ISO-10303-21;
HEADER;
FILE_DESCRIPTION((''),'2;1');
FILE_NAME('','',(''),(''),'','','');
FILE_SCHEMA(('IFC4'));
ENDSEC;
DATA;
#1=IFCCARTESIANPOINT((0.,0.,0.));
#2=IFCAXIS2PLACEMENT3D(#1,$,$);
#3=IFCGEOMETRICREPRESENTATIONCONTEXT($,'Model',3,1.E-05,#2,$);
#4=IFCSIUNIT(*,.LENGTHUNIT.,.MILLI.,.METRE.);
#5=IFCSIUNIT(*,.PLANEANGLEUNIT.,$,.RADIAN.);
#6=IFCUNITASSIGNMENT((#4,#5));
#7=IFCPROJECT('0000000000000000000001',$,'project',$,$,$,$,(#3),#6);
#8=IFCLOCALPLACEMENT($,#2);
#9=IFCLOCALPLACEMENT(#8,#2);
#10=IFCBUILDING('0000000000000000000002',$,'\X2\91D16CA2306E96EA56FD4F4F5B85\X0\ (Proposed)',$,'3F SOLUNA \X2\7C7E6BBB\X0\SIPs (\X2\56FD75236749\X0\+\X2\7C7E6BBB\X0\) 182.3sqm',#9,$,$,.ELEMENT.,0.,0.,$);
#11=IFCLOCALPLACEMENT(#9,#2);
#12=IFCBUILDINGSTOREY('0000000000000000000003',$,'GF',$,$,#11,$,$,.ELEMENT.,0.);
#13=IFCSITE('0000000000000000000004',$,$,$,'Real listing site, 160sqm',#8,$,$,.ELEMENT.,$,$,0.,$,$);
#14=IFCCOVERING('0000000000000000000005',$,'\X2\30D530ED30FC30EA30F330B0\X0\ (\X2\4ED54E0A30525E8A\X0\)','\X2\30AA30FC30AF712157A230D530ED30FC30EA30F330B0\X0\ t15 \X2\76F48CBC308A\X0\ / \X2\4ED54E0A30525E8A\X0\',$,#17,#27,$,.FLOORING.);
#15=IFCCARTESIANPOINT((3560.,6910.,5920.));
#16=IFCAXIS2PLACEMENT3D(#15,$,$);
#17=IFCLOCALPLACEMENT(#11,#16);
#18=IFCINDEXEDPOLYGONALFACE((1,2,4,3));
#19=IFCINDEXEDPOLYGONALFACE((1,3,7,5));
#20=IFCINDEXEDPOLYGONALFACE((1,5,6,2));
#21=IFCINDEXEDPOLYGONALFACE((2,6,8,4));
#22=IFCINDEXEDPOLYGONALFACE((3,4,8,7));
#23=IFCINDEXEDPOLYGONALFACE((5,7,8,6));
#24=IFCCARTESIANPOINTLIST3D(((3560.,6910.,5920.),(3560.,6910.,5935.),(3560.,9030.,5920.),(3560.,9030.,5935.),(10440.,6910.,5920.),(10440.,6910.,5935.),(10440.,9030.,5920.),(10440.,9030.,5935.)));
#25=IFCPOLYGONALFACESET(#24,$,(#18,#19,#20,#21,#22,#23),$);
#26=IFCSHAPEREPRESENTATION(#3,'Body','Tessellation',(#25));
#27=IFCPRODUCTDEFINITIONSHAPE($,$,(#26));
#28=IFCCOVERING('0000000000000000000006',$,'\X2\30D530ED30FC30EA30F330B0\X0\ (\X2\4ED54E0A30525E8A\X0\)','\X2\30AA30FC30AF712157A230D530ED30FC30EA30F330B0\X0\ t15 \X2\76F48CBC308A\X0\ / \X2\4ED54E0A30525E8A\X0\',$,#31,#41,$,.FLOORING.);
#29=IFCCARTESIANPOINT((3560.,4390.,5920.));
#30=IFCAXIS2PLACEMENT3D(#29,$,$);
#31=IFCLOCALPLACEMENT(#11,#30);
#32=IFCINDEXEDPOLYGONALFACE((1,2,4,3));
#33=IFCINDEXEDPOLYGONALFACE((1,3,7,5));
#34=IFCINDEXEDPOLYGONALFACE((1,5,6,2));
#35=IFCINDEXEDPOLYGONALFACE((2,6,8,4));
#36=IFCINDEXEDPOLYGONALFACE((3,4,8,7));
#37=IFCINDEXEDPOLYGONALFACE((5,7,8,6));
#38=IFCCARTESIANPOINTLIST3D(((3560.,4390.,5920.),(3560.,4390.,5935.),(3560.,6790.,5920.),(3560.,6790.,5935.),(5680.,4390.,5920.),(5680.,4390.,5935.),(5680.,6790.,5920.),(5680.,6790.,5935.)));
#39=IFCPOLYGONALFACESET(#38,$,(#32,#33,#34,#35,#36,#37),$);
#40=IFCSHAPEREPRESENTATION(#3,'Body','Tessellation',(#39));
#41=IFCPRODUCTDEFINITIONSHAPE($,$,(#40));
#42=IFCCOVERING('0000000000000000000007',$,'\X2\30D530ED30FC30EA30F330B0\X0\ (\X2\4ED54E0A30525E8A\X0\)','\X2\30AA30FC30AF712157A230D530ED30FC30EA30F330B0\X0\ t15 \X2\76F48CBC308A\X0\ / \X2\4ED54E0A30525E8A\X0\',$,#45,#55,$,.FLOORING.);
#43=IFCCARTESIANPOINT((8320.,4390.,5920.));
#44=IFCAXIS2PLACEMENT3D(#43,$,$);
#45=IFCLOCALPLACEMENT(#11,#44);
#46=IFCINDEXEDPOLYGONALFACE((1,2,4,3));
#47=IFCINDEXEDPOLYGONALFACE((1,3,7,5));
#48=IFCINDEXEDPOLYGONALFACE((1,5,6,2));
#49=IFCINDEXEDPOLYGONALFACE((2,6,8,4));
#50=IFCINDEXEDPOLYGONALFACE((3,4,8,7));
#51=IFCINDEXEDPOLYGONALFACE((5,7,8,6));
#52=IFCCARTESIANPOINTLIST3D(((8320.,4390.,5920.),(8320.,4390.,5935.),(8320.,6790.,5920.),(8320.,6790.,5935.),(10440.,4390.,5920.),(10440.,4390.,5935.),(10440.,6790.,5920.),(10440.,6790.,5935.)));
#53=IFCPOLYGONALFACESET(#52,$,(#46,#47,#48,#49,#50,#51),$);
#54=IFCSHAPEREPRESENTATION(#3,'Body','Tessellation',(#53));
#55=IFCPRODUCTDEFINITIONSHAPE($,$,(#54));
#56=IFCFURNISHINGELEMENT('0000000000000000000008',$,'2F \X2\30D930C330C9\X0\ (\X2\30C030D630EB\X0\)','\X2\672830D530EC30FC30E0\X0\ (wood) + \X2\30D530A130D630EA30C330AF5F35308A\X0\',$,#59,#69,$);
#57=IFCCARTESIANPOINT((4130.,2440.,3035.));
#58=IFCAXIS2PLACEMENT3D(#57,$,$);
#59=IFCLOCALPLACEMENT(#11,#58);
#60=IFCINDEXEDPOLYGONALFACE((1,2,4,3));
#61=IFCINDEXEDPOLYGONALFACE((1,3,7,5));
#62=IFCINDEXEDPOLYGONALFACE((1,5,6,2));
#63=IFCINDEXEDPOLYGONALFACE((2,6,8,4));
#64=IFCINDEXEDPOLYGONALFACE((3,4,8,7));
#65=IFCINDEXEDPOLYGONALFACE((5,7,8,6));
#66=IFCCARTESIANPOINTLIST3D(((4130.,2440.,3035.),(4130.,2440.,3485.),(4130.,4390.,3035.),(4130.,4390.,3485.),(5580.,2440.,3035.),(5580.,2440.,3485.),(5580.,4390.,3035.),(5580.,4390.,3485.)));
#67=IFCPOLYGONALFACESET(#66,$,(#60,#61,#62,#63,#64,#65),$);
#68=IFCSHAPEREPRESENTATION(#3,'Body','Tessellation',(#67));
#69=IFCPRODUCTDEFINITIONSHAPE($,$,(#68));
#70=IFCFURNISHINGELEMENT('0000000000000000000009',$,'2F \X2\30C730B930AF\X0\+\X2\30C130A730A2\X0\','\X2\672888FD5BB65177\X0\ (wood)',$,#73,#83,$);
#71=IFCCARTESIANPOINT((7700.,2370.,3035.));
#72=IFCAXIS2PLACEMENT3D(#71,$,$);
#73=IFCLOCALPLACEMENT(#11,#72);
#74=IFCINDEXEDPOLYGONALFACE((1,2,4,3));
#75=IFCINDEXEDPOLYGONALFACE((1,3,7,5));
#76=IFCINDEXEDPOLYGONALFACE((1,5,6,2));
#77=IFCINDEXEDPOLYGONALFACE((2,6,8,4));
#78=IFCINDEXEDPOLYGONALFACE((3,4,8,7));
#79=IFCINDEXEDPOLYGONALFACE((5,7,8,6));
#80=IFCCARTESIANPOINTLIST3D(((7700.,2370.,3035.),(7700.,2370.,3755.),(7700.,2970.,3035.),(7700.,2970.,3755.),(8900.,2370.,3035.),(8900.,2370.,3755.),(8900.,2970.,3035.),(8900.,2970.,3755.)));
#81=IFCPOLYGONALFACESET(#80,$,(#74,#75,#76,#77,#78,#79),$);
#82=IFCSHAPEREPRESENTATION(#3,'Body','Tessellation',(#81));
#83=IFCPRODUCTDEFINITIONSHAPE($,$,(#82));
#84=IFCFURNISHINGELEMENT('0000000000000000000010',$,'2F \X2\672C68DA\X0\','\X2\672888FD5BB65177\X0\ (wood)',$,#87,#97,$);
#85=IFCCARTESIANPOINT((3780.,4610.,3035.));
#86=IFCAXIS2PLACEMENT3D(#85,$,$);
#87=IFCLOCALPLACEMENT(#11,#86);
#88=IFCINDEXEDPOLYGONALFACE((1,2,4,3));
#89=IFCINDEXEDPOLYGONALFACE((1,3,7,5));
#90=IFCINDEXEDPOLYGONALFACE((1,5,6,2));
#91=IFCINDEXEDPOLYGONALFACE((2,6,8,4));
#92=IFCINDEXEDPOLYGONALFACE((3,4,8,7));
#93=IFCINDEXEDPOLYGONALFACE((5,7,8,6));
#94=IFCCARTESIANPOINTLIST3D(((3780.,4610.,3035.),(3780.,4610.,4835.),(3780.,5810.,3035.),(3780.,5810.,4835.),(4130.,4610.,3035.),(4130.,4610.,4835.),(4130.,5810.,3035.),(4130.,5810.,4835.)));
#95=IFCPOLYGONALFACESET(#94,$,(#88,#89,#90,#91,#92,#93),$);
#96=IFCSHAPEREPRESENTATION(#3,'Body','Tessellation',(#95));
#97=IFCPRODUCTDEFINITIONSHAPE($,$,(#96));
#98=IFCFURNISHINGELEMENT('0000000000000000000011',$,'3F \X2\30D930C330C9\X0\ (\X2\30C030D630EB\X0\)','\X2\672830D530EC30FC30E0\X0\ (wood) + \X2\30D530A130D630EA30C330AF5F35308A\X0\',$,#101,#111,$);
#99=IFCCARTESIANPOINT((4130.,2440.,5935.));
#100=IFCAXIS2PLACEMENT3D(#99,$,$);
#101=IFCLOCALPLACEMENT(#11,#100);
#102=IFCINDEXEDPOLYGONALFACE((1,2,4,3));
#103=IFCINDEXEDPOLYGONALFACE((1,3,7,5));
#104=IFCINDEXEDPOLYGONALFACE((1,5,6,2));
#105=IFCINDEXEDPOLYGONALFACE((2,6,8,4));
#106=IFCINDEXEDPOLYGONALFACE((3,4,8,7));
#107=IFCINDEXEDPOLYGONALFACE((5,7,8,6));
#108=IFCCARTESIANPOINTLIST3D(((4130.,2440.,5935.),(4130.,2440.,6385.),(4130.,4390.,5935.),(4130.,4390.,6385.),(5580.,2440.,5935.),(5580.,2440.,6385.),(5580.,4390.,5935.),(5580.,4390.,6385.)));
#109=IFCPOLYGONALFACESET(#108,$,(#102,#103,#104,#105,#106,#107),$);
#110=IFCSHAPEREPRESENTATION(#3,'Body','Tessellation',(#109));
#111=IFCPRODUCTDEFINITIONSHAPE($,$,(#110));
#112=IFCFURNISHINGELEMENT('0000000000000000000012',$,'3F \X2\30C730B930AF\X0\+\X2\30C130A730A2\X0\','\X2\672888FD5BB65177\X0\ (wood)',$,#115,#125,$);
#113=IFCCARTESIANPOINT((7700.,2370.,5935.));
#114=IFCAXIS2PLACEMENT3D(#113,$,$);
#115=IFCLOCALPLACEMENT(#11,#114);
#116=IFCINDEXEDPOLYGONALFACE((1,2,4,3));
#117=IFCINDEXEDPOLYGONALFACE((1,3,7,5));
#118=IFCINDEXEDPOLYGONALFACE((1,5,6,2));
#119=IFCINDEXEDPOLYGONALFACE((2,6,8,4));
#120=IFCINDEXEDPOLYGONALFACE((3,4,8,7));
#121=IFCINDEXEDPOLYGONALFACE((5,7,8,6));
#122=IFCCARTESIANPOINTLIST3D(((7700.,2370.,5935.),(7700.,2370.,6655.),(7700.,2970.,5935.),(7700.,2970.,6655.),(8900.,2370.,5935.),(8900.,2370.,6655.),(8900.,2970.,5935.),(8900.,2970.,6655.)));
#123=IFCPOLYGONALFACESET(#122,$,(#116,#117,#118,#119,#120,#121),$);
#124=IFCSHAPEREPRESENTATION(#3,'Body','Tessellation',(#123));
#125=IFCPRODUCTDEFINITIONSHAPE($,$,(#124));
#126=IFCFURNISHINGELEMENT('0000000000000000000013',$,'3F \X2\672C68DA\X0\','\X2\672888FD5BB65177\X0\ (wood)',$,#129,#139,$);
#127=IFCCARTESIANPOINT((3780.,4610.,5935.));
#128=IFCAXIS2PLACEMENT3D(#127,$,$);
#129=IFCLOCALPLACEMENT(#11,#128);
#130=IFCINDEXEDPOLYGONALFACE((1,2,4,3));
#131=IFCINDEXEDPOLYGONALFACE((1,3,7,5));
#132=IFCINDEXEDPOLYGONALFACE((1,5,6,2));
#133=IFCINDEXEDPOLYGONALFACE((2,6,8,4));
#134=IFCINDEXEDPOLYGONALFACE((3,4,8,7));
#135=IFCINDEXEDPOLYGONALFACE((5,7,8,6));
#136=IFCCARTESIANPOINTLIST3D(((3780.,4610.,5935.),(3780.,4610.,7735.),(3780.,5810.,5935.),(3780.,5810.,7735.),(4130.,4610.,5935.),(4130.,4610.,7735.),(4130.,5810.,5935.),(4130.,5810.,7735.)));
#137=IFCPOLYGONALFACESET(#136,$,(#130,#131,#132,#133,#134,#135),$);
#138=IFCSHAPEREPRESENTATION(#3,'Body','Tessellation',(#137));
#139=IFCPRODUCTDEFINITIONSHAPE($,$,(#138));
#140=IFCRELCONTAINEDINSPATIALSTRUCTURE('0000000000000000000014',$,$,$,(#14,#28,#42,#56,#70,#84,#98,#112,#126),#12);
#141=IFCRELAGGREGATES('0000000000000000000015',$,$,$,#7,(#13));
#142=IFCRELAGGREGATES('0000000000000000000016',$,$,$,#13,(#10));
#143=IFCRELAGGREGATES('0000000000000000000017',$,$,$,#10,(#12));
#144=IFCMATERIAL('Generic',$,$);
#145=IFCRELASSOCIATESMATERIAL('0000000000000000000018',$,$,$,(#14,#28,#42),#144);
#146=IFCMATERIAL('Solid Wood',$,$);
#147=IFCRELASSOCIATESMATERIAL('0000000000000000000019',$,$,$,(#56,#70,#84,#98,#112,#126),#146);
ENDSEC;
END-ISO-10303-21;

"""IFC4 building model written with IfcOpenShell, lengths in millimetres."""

from ifc_helpers import new_model, si_unit, frame, frame_2d, origin, place, context, project, spatial, rectangle, extrude, material, element, save


model = new_model("IFC4")

# Units and contexts
model_context = context("Model", 3, precision=1e-05, world=origin())
ifc_project = project(units=[si_unit("LENGTHUNIT", "METRE", prefix="MILLI"), si_unit("PLANEANGLEUNIT", "RADIAN")], contexts=[model_context])

# Site, building, storey
site_placement = place(None, origin())
site = spatial("IfcSite", under=ifc_project, at=site_placement, ObjectType="Real listing site, 160sqm", CompositionType="ELEMENT", RefElevation=0.0)
building_placement = place(site_placement, origin())
building = spatial("IfcBuilding", under=site, at=building_placement, Name="金沢の雪国住宅 (Proposed)", ObjectType="3F SOLUNA 籾殻SIPs (国産杉+籾殻) 182.3sqm", CompositionType="ELEMENT", ElevationOfRefHeight=0.0, ElevationOfTerrain=0.0)
storey_placement = place(building_placement, origin())
storey = spatial("IfcBuildingStorey", under=building, at=storey_placement, Name="GF", CompositionType="ELEMENT", Elevation=0.0)

# Shared definitions
ifc_material_1 = material(Name="Solid Wood")

# Shared definitions
ifc_material_2 = material(Name="Generic")

# Coverings
covering_1_placement = place(storey_placement, frame((3560.0, 6910.0, 5920.0)))
element("IfcCovering", 1, at=covering_1_placement, inside=storey, material=ifc_material_2, Name="フローリング (仕上げ床)", Description="オーク無垢フローリング t15 直貼り / 仕上げ床", PredefinedType="FLOORING", context=model_context, shape_type="SweptSolid", body=[
    extrude(rectangle(XDim=6880.0, YDim=2120.0, at=frame_2d((3440.0, 1060.0))), frame((3560.0, 6910.0, 5920.0)), (0.0, 0.0, 1.0), 15.0),
])
covering_2_placement = place(storey_placement, frame((3560.0, 4390.0, 5920.0)))
element("IfcCovering", 2, at=covering_2_placement, inside=storey, material=ifc_material_2, Name="フローリング (仕上げ床)", Description="オーク無垢フローリング t15 直貼り / 仕上げ床", PredefinedType="FLOORING", context=model_context, shape_type="SweptSolid", body=[
    extrude(rectangle(XDim=2120.0, YDim=2400.0, at=frame_2d((1060.0, 1200.0))), frame((3560.0, 4390.0, 5920.0)), (0.0, 0.0, 1.0), 15.0),
])
covering_3_placement = place(storey_placement, frame((8320.0, 4390.0, 5920.0)))
element("IfcCovering", 3, at=covering_3_placement, inside=storey, material=ifc_material_2, Name="フローリング (仕上げ床)", Description="オーク無垢フローリング t15 直貼り / 仕上げ床", PredefinedType="FLOORING", context=model_context, shape_type="SweptSolid", body=[
    extrude(rectangle(XDim=2120.0, YDim=2400.0, at=frame_2d((1060.0, 1200.0))), frame((8320.0, 4390.0, 5920.0)), (0.0, 0.0, 1.0), 15.0),
])

# Furnishing elements
furnishing_1_placement = place(storey_placement, frame((4130.0, 2440.0, 3035.0)))
element("IfcFurnishingElement", 4, at=furnishing_1_placement, inside=storey, material=ifc_material_1, Name="2F ベッド (ダブル)", Description="木フレーム (wood) + ファブリック張り", context=model_context, shape_type="SweptSolid", body=[
    extrude(rectangle(XDim=1450.0, YDim=1950.0, at=frame_2d((725.0, 975.0))), frame((4130.0, 2440.0, 3035.0)), (0.0, 0.0, 1.0), 450.0),
])
furnishing_2_placement = place(storey_placement, frame((7700.0, 2370.0, 3035.0)))
element("IfcFurnishingElement", 5, at=furnishing_2_placement, inside=storey, material=ifc_material_1, Name="2F デスク+チェア", Description="木製家具 (wood)", context=model_context, shape_type="SweptSolid", body=[
    extrude(rectangle(XDim=1200.0, YDim=600.0, at=frame_2d((600.0, 300.0))), frame((7700.0, 2370.0, 3035.0)), (0.0, 0.0, 1.0), 720.0),
])
furnishing_3_placement = place(storey_placement, frame((3780.0, 4610.0, 3035.0)))
element("IfcFurnishingElement", 6, at=furnishing_3_placement, inside=storey, material=ifc_material_1, Name="2F 本棚", Description="木製家具 (wood)", context=model_context, shape_type="SweptSolid", body=[
    extrude(rectangle(XDim=350.0, YDim=1200.0, at=frame_2d((175.0, 600.0))), frame((3780.0, 4610.0, 3035.0)), (0.0, 0.0, 1.0), 1800.0),
])
furnishing_4_placement = place(storey_placement, frame((4130.0, 2440.0, 5935.0)))
element("IfcFurnishingElement", 7, at=furnishing_4_placement, inside=storey, material=ifc_material_1, Name="3F ベッド (ダブル)", Description="木フレーム (wood) + ファブリック張り", context=model_context, shape_type="SweptSolid", body=[
    extrude(rectangle(XDim=1450.0, YDim=1950.0, at=frame_2d((725.0, 975.0))), frame((4130.0, 2440.0, 5935.0)), (0.0, 0.0, 1.0), 450.0),
])
furnishing_5_placement = place(storey_placement, frame((7700.0, 2370.0, 5935.0)))
element("IfcFurnishingElement", 8, at=furnishing_5_placement, inside=storey, material=ifc_material_1, Name="3F デスク+チェア", Description="木製家具 (wood)", context=model_context, shape_type="SweptSolid", body=[
    extrude(rectangle(XDim=1200.0, YDim=600.0, at=frame_2d((600.0, 300.0))), frame((7700.0, 2370.0, 5935.0)), (0.0, 0.0, 1.0), 720.0),
])
furnishing_6_placement = place(storey_placement, frame((3780.0, 4610.0, 5935.0)))
element("IfcFurnishingElement", 9, at=furnishing_6_placement, inside=storey, material=ifc_material_1, Name="3F 本棚", Description="木製家具 (wood)", context=model_context, shape_type="SweptSolid", body=[
    extrude(rectangle(XDim=350.0, YDim=1200.0, at=frame_2d((175.0, 600.0))), frame((3780.0, 4610.0, 5935.0)), (0.0, 0.0, 1.0), 1800.0),
])

save(model, "model.ifc")
